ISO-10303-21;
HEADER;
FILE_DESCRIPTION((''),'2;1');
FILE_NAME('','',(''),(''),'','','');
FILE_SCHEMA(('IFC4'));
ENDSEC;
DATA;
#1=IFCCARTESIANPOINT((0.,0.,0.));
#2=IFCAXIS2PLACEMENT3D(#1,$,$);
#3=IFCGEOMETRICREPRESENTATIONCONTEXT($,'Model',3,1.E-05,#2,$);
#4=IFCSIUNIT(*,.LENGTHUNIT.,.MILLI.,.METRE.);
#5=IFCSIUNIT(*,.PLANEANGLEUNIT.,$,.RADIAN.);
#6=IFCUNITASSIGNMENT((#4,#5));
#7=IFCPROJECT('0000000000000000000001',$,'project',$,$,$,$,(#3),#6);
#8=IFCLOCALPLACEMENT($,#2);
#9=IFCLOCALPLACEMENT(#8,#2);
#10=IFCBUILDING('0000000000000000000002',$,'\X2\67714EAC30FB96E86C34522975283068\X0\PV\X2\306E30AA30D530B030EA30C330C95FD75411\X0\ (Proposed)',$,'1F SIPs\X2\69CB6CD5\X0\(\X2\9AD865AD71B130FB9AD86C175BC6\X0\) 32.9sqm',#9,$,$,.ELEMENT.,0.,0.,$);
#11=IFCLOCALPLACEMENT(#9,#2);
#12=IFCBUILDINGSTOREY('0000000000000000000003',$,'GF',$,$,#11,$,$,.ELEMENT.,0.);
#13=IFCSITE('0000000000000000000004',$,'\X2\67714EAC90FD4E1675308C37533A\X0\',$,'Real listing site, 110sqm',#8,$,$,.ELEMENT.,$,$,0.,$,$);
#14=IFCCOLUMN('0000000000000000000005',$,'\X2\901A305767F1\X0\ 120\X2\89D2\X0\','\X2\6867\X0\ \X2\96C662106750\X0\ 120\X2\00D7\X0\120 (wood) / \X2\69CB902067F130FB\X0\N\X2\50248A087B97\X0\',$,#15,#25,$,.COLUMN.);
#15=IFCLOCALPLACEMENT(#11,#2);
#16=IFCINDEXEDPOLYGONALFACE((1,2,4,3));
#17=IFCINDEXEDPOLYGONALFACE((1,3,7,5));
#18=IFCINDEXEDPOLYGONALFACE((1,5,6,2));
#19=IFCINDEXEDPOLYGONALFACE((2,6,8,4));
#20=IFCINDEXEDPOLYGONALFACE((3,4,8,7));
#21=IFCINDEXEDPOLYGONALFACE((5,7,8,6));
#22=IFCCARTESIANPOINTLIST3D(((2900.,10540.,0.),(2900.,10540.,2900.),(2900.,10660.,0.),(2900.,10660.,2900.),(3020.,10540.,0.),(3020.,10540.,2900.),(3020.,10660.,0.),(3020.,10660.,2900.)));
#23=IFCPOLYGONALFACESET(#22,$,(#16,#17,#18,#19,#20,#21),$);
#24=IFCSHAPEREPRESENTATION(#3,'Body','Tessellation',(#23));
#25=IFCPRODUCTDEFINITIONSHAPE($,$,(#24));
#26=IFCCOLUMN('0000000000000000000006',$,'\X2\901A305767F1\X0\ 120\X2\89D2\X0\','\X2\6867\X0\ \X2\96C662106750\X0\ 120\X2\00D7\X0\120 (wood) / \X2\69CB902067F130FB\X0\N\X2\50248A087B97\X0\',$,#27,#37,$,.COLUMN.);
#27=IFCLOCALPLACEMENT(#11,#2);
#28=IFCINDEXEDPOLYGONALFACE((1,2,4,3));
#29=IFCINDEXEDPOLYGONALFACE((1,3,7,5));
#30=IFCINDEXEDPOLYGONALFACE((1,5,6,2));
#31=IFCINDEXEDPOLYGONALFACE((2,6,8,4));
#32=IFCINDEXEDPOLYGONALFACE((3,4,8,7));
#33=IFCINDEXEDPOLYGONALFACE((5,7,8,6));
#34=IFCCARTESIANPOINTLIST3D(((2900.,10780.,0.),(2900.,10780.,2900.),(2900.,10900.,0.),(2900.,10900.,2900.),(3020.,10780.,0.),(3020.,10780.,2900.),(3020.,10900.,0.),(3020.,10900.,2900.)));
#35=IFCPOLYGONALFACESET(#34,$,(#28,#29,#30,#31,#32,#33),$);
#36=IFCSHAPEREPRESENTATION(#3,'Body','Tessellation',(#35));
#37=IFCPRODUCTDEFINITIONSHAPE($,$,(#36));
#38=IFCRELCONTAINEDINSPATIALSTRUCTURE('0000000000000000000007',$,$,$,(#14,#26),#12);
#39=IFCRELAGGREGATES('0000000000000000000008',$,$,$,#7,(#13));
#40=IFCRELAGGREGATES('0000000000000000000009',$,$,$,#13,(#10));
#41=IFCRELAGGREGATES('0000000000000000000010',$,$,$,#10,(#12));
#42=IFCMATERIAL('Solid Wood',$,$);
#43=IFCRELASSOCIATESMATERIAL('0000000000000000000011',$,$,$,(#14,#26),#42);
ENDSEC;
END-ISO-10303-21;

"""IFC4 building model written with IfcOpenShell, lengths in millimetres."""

from ifc_helpers import new_model, si_unit, frame, frame_2d, origin, place, context, project, spatial, rectangle, extrude, material, element, save


model = new_model("IFC4")

# Units and contexts
model_context = context("Model", 3, precision=1e-05, world=origin())
ifc_project = project(units=[si_unit("LENGTHUNIT", "METRE", prefix="MILLI"), si_unit("PLANEANGLEUNIT", "RADIAN")], contexts=[model_context])

# Site, building, storey
site_placement = place(None, origin())
site = spatial("IfcSite", under=ifc_project, at=site_placement, Name="東京都世田谷区", ObjectType="Real listing site, 110sqm", CompositionType="ELEMENT", RefElevation=0.0)
building_placement = place(site_placement, origin())
building = spatial("IfcBuilding", under=site, at=building_placement, Name="東京・雨水利用とPVのオフグリッド志向 (Proposed)", ObjectType="1F SIPs構法(高断熱・高気密) 32.9sqm", CompositionType="ELEMENT", ElevationOfRefHeight=0.0, ElevationOfTerrain=0.0)
storey_placement = place(building_placement, origin())
storey = spatial("IfcBuildingStorey", under=building, at=storey_placement, Name="GF", CompositionType="ELEMENT", Elevation=0.0)

# Columns
ifc_material_1 = material(Name="Solid Wood")
column_1_placement = place(storey_placement, frame((1450.0, 5270.0, 0.0)))
element("IfcColumn", 1, at=column_1_placement, inside=storey, material=ifc_material_1, Name="通し柱 120角", Description="桧 集成材 120×120 (wood) / 構造柱・N値計算", PredefinedType="COLUMN", context=model_context, shape_type="SweptSolid", body=[
    extrude(rectangle(XDim=120.0, YDim=120.0, at=frame_2d((60.0, 60.0))), frame((1450.0, 5270.0, 0.0)), (0.0, 0.0, 1.0), 2900.0),
])
column_2_placement = place(storey_placement, frame((1450.0, 5390.0, 0.0)))
element("IfcColumn", 2, at=column_2_placement, inside=storey, material=ifc_material_1, Name="通し柱 120角", Description="桧 集成材 120×120 (wood) / 構造柱・N値計算", PredefinedType="COLUMN", context=model_context, shape_type="SweptSolid", body=[
    extrude(rectangle(XDim=120.0, YDim=120.0, at=frame_2d((60.0, 60.0))), frame((1450.0, 5390.0, 0.0)), (0.0, 0.0, 1.0), 2900.0),
])

save(model, "model.ifc")
